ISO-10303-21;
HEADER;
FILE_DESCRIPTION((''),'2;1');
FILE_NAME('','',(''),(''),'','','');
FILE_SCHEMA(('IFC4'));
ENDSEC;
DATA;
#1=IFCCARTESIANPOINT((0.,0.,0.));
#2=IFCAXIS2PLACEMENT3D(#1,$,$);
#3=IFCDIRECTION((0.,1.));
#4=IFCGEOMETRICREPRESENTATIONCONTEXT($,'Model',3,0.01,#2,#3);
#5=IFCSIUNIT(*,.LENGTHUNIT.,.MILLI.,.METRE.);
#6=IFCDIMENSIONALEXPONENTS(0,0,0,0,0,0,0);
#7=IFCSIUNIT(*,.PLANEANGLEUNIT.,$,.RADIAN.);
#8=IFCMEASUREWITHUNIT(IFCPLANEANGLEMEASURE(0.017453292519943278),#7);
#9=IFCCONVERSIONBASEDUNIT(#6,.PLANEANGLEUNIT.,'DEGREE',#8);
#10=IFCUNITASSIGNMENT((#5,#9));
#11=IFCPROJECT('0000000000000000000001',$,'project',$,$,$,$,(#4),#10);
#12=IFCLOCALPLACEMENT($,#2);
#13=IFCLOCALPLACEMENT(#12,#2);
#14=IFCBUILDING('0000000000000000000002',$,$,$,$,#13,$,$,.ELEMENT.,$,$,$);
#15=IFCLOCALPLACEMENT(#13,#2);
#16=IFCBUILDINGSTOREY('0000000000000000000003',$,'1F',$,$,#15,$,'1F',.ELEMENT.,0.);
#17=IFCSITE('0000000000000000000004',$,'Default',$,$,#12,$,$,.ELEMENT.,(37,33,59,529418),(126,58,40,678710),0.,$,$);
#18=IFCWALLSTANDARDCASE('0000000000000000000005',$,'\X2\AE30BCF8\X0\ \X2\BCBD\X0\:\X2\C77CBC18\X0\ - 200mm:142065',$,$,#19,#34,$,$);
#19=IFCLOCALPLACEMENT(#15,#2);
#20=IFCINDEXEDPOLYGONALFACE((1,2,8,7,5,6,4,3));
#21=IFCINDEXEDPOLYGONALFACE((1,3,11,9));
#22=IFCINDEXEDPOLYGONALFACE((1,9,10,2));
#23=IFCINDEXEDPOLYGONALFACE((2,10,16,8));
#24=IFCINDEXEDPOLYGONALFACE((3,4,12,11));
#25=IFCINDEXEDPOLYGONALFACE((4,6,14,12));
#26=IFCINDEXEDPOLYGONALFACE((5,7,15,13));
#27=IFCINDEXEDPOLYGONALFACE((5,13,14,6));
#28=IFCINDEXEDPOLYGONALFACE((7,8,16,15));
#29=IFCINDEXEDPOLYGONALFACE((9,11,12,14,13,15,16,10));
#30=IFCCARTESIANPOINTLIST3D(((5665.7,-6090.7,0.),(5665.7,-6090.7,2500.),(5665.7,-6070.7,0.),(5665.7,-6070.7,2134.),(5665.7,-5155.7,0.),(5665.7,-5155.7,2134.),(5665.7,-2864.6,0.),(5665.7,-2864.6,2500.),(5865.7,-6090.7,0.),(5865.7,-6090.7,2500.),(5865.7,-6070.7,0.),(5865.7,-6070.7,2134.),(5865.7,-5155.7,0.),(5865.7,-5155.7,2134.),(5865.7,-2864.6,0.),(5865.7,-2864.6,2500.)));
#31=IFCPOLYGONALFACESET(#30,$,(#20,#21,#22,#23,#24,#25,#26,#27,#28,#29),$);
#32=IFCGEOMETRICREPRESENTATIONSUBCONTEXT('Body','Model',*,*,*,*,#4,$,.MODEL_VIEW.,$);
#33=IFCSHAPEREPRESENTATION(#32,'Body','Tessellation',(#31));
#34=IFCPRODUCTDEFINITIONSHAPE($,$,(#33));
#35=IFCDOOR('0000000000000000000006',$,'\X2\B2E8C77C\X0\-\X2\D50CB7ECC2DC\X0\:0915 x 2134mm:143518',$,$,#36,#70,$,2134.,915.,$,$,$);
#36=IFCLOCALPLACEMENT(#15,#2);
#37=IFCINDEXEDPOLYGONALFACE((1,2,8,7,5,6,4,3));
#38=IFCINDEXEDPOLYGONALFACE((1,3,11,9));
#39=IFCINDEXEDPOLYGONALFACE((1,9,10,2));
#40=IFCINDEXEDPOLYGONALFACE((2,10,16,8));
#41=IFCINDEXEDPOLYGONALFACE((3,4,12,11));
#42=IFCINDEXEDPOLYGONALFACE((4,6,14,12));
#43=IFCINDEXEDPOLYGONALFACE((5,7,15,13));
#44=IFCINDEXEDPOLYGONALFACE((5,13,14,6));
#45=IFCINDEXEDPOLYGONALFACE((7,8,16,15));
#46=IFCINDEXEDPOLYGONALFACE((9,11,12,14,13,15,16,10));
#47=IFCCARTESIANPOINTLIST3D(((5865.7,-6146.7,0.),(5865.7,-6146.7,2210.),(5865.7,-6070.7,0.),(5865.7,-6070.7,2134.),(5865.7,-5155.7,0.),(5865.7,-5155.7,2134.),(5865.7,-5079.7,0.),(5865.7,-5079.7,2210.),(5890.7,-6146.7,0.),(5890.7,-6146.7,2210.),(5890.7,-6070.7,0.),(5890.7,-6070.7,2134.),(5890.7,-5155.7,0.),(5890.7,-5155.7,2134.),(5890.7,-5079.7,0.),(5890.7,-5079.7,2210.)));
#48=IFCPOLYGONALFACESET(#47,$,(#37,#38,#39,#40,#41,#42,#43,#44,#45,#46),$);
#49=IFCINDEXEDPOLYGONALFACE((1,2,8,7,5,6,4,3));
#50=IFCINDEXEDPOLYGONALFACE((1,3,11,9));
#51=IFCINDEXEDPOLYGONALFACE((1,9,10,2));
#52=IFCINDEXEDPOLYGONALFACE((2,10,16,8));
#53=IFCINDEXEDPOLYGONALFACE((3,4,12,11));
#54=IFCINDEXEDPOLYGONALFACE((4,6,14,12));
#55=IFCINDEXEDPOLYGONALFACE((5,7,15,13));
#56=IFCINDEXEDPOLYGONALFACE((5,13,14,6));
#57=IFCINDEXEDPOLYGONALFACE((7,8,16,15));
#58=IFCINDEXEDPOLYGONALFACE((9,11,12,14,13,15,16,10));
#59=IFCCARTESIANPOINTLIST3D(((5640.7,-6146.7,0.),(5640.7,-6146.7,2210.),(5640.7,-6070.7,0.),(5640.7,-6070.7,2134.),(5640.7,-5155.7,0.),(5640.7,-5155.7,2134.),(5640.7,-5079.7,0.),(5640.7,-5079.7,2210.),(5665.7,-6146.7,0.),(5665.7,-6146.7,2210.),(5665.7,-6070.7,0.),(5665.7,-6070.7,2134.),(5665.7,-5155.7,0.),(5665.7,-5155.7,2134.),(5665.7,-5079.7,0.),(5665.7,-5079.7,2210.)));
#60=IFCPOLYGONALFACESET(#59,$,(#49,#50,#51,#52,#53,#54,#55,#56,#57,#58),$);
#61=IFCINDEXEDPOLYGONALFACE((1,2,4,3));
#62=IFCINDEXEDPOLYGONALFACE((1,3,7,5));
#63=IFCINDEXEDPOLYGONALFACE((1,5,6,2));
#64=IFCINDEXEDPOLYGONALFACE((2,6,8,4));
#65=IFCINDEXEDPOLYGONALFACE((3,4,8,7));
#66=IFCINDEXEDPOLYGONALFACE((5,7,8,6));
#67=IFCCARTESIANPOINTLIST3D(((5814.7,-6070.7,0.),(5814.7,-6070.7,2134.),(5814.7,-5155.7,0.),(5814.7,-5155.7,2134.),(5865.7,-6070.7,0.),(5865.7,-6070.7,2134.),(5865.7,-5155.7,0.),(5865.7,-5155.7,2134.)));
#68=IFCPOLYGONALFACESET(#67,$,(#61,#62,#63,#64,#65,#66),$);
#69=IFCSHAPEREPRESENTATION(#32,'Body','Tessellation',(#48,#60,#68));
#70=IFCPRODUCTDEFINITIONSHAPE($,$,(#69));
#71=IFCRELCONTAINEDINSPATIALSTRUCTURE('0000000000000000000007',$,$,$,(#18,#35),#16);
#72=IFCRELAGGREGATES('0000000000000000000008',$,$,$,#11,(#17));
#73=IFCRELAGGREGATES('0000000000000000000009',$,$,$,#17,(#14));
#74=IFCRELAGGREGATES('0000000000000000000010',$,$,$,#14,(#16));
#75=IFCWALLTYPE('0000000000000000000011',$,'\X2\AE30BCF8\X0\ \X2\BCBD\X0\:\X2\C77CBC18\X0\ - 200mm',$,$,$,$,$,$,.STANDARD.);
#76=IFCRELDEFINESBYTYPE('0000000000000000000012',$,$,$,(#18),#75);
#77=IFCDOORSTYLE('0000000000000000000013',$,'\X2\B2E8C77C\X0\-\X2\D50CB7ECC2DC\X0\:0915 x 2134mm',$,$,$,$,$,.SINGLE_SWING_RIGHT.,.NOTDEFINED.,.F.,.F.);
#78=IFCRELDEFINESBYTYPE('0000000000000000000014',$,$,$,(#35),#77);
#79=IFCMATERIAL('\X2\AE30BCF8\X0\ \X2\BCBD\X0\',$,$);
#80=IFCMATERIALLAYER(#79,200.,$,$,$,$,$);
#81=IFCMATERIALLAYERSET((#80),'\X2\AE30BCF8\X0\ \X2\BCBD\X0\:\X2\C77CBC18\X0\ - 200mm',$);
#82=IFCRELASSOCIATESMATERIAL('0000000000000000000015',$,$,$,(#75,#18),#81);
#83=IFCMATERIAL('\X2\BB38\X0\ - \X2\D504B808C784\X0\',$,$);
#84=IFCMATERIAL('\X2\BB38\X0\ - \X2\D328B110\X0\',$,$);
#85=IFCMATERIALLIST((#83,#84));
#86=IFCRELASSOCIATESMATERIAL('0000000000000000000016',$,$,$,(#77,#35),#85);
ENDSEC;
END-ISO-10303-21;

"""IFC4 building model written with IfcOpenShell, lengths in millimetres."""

from ifc_helpers import new_model, entity, si_unit, converted_unit, direction, frame, frame_2d, origin, place, context, subcontext, project, spatial, polyline, rectangle, outline, extrude, source, transform, mapped, material, material_list, layer, layer_set, layer_usage, type_object, type_shapes, element, fill, save


model = new_model("IFC4")

# Units and contexts
model_context = context("Model", 3, precision=0.01, world=origin(), true_north=direction((0.0, 1.0)))
body_context = subcontext(model_context, "Body", "Model", "MODEL_VIEW")
ifc_project = project(units=[si_unit("LENGTHUNIT", "METRE", prefix="MILLI"), converted_unit("PLANEANGLEUNIT", "DEGREE", entity("IfcPlaneAngleMeasure", 0.017453292519943278), si_unit("PLANEANGLEUNIT", "RADIAN"), dimensions=[0, 0, 0, 0, 0, 0, 0])], contexts=[model_context])

# Site, building, storey
site_placement = place(None, origin())
site = spatial("IfcSite", under=ifc_project, at=site_placement, Name="Default", CompositionType="ELEMENT", RefLatitude=(37, 33, 59, 529418), RefLongitude=(126, 58, 40, 678710), RefElevation=0.0)
building_placement = place(site_placement, origin())
building = spatial("IfcBuilding", under=site, at=building_placement, CompositionType="ELEMENT")
storey_placement = place(building_placement, origin())
storey = spatial("IfcBuildingStorey", under=building, at=storey_placement, Name="1F", LongName="1F", CompositionType="ELEMENT", Elevation=0.0)

# Shared definitions
ifc_material_1 = material(Name="기본 벽")
ifc_layer = layer(ifc_material_1, 200.0)
ifc_layer_set = layer_set([ifc_layer], Name="기본 벽:일반 - 200mm")
wall_type = type_object("IfcWallType", Name="기본 벽:일반 - 200mm", PredefinedType="STANDARD", material=ifc_layer_set)

# Wall, opening, door
ifc_layer_usage_1 = layer_usage(ifc_layer_set, "AXIS2", "NEGATIVE", 100.0)
wall_1_placement = place(storey_placement, frame((5765.7, -2864.6, 0.0), z_axis=(0.0, 0.0, 1.0), x_axis=(0.0, -1.0, 0.0)))
wall_1 = element("IfcWallStandardCase", 1, at=wall_1_placement, inside=storey, type_object=wall_type, material=ifc_layer_usage_1, Name="기본 벽:일반 - 200mm:142065", context=body_context, shape_type="SweptSolid", body=[
    extrude(rectangle(XDim=3226.1, YDim=200.0, at=frame_2d((1613.1, 0.0), x_axis=(-1.0, 0.0))), origin(), (0.0, 0.0, 1.0), 2500.0),
])
opening_1_placement = place(wall_1_placement, frame((2291.1, -100.0, 0.0)))
opening_1 = element("IfcOpeningElement", 2, at=opening_1_placement, cuts=wall_1, ObjectType="Opening", context=body_context, shape_type="SweptSolid", body=[
    extrude(rectangle(XDim=915.0, YDim=2134.0, at=frame_2d((1067.0, 457.5), x_axis=(0.0, 1.0))), frame((0.0, 0.0, 0.0), z_axis=(0.0, 1.0, 0.0), x_axis=(0.0, 0.0, 1.0)), (0.0, 0.0, 1.0), 200.0),
])
ifc_material_2 = material(Name="문 - 프레임")
ifc_material_3 = material(Name="문 - 패널")
ifc_material_list_1 = material_list([ifc_material_2, ifc_material_3])
door_style_1 = type_object("IfcDoorStyle", Name="단일-플러시:0915 x 2134mm", ConstructionType="NOTDEFINED", OperationType="SINGLE_SWING_RIGHT", ParameterTakesPrecedence=False, Sizeable=False, material=ifc_material_list_1)
shared_shape_1 = source(origin(), body_context, "Body", "SweptSolid", [
    extrude(outline(polyline([(-533.5, -1124.0), (533.5, -1124.0), (533.5, 1086.0), (457.5, 1086.0), (457.5, -1048.0), (-457.5, -1048.0), (-457.5, 1086.0), (-533.5, 1086.0), (-533.5, -1124.0)])), frame((457.5, 200.0, 1086.0), z_axis=(0.0, 1.0, 0.0), x_axis=(1.0, 0.0, 0.0)), (0.0, 0.0, 1.0), 25.0),
    extrude(outline(polyline([(-1124.0, -533.5), (1086.0, -533.5), (1086.0, -457.5), (-1048.0, -457.5), (-1048.0, 457.5), (1086.0, 457.5), (1086.0, 533.5), (-1124.0, 533.5), (-1124.0, -533.5)])), frame((457.5, -25.0, 1086.0), z_axis=(0.0, 1.0, 0.0), x_axis=(0.0, 0.0, -1.0)), (0.0, 0.0, 1.0), 25.0),
    extrude(rectangle(XDim=51.0, YDim=915.0, at=frame_2d((0.0, 0.0), x_axis=(1.0, 0.0))), frame((457.5, 174.5, 0.0), z_axis=(0.0, 0.0, 1.0), x_axis=(0.0, 1.0, 0.0)), (0.0, 0.0, 1.0), 2134.0),
])
type_shapes(door_style_1, [shared_shape_1])
door_1_placement = place(opening_1_placement, origin())
door_1 = element("IfcDoor", 3, at=door_1_placement, inside=storey, type_object=door_style_1, material=ifc_material_list_1, Name="단일-플러시:0915 x 2134mm:143518", OverallHeight=2134.0, OverallWidth=915.0, context=body_context, shape_type="MappedRepresentation", body=[
    mapped(shared_shape_1, transform((0.0, 0.0, 0.0), scale=1.0)),
])
fill(opening_1, door_1)

save(model, "model.ifc")
